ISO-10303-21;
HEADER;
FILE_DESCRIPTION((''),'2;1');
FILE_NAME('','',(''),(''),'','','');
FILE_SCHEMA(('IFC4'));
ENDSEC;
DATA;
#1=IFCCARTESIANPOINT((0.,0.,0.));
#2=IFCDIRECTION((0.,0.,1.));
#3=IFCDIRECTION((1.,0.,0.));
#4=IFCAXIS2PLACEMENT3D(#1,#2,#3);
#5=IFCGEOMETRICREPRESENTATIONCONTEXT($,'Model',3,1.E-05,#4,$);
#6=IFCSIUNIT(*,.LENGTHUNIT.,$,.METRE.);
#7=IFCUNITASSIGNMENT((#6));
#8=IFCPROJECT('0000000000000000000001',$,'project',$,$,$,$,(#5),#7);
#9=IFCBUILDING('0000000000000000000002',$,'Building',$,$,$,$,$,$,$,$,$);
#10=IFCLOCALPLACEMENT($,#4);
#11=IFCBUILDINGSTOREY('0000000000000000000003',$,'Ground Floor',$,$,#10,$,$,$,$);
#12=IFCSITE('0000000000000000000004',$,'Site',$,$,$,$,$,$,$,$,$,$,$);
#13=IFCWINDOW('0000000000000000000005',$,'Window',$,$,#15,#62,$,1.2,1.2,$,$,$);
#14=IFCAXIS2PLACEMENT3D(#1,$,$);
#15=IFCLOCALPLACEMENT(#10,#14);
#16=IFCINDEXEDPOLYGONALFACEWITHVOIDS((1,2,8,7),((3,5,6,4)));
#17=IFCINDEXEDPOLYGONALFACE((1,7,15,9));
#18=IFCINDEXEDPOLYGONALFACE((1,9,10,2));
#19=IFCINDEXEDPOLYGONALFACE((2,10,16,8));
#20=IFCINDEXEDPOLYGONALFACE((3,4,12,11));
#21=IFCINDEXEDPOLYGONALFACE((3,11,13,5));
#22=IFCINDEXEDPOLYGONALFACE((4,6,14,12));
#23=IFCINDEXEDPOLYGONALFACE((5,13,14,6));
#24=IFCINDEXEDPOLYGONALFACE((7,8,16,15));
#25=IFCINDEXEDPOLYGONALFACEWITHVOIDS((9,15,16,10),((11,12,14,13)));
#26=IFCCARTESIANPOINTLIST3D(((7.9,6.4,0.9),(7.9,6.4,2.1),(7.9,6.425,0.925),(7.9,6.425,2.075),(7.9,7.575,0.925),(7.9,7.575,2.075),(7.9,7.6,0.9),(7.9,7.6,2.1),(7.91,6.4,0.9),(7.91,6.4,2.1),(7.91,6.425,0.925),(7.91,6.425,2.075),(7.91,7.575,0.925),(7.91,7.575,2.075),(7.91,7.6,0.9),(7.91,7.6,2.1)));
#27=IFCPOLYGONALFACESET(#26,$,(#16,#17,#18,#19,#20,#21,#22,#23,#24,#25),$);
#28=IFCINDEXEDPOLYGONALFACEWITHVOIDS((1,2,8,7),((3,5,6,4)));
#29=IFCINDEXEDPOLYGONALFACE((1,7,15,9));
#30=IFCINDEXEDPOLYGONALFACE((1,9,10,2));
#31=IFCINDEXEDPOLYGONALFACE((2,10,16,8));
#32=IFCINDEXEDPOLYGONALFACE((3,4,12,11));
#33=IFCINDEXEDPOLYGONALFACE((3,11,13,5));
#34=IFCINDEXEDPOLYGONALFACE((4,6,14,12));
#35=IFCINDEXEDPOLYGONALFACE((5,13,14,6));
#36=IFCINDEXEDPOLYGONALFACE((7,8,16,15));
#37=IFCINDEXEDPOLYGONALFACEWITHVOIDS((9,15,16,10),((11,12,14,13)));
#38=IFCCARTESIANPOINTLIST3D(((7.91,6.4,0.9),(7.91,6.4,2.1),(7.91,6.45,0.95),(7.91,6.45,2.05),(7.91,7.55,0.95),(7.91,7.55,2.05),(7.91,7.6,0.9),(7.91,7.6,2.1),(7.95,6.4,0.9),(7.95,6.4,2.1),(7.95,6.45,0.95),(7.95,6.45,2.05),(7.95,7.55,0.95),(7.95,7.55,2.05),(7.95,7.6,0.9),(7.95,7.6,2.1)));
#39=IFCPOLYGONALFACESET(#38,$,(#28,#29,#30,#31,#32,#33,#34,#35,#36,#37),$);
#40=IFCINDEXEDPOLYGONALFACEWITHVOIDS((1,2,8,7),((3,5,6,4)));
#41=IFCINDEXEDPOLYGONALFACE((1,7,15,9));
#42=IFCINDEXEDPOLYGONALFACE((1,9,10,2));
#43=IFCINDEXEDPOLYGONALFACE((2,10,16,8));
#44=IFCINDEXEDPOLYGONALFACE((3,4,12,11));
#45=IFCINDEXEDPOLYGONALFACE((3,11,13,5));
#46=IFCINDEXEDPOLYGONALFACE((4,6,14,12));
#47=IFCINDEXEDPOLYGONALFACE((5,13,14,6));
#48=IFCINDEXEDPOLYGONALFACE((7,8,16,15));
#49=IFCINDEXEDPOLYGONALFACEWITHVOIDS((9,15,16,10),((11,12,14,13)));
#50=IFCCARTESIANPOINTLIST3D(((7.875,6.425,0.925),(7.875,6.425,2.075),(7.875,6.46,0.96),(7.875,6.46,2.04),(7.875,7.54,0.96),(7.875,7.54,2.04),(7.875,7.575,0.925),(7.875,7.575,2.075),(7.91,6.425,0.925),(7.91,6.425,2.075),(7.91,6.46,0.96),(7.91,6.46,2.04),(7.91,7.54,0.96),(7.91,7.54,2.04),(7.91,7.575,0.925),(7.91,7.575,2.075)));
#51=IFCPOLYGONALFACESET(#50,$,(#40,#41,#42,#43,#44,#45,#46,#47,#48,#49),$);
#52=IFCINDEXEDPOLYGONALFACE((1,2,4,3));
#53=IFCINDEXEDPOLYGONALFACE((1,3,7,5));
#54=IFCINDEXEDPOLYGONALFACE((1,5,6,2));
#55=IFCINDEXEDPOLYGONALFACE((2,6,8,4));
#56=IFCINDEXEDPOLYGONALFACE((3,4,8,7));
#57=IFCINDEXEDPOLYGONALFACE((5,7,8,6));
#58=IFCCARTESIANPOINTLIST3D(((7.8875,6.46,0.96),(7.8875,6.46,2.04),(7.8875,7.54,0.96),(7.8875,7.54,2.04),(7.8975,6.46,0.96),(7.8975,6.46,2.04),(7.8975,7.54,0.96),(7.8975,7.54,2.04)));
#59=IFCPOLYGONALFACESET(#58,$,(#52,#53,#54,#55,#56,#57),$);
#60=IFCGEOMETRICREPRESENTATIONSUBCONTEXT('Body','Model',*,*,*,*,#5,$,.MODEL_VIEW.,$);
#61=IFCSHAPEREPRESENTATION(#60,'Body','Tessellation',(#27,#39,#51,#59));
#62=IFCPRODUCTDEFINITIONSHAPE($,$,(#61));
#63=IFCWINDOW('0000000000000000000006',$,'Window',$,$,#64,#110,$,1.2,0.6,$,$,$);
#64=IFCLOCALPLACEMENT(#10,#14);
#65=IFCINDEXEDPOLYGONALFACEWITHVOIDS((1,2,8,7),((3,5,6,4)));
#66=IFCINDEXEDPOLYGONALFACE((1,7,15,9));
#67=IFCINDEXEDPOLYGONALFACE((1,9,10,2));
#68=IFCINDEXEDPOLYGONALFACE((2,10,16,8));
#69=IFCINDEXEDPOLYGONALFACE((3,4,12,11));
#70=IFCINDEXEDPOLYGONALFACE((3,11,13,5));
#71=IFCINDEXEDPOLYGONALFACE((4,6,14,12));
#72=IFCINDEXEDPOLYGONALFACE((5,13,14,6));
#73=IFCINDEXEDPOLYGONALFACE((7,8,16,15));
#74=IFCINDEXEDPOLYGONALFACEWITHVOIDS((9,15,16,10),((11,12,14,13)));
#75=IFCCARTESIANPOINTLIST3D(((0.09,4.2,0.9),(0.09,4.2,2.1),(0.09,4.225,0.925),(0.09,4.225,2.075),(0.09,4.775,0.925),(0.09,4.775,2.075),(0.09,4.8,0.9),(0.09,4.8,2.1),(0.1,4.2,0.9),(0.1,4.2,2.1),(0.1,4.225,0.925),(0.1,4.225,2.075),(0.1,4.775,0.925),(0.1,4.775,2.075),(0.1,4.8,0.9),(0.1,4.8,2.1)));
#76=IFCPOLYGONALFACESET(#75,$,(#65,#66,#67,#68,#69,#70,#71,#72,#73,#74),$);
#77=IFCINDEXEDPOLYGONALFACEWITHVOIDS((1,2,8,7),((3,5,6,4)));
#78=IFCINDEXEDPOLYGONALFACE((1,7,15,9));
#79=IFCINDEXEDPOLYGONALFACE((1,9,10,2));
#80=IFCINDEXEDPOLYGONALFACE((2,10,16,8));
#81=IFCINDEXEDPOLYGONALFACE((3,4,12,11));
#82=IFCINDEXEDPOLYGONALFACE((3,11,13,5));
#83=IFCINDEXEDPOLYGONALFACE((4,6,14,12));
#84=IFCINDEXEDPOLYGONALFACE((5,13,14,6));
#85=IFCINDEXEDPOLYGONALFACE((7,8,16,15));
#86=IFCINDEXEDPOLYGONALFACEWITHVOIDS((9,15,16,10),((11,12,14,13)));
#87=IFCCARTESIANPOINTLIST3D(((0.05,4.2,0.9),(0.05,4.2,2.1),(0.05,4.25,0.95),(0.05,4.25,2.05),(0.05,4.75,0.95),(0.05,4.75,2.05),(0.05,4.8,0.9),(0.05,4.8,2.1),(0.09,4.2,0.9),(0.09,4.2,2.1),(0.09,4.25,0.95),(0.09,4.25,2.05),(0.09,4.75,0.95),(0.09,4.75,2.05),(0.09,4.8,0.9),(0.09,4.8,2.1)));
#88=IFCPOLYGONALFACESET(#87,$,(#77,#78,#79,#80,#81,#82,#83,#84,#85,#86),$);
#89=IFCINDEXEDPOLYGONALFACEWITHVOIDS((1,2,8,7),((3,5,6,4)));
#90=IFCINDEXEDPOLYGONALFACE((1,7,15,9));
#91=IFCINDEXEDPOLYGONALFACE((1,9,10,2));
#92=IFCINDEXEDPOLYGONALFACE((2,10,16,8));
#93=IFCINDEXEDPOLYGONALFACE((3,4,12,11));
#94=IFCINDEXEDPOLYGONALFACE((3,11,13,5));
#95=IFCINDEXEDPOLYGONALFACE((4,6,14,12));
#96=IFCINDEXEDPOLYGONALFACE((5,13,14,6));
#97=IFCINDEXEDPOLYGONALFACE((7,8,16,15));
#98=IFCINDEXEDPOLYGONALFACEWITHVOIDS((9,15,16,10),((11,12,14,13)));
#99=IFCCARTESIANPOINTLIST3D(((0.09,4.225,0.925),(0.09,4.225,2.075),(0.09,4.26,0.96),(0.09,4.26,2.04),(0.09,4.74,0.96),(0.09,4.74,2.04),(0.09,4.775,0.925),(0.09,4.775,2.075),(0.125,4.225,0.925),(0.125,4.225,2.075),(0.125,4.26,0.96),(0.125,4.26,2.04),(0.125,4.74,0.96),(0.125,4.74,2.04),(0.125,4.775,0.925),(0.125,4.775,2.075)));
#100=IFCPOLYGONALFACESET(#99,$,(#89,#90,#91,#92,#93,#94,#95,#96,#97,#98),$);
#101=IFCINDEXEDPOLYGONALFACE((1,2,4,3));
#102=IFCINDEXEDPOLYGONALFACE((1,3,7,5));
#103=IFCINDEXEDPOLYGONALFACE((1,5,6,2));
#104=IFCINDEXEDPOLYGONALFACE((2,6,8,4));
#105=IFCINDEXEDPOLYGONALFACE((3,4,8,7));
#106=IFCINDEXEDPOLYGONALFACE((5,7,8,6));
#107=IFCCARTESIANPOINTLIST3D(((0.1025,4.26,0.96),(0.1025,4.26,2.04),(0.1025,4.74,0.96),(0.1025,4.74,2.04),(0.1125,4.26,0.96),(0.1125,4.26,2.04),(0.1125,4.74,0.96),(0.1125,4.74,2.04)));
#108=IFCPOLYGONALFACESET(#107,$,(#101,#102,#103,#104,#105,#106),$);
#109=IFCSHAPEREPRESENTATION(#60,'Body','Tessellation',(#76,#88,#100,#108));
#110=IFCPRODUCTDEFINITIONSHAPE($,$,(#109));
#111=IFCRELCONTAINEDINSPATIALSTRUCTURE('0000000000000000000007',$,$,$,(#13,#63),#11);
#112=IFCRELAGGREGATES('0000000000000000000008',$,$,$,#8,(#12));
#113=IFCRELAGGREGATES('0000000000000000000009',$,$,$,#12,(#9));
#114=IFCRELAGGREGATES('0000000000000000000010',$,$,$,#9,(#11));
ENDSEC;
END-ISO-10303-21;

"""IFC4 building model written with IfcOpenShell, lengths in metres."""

from ifc_helpers import new_model, si_unit, frame, origin_with_axes, place, context, subcontext, project, spatial, line, indexed_curve, outline, extrude, element, save


model = new_model("IFC4")

# Units and contexts
model_context = context("Model", 3, precision=1e-05, world=origin_with_axes())
body_context = subcontext(model_context, "Body", "Model", "MODEL_VIEW")
ifc_project = project(units=[si_unit("LENGTHUNIT", "METRE")], contexts=[model_context])

# Site, building, storey
site = spatial("IfcSite", under=ifc_project, Name="Site")
building = spatial("IfcBuilding", under=site, Name="Building")
storey_placement = place(None, origin_with_axes())
storey = spatial("IfcBuildingStorey", under=building, at=storey_placement, Name="Ground Floor")

# Windows
window_1_placement = place(storey_placement, frame((8.0, 6.4, 0.9), z_axis=(0.0, 0.0, 1.0), x_axis=(0.0, 1.0, 0.0)))
element("IfcWindow", 1, at=window_1_placement, inside=storey, Name="Window", OverallHeight=1.2, OverallWidth=1.2, context=body_context, shape_type="SweptSolid", body=[
    extrude(outline(indexed_curve([(0.0, 0.0), (1.2, 0.0), (1.2, 1.2), (0.0, 1.2)], segments=[line(1, 2, 3, 4, 1)]), holes=[indexed_curve([(0.025, 0.025), (1.175, 0.025), (1.175, 1.175), (0.025, 1.175)], segments=[line(1, 2, 3, 4, 1)])]), frame((0.0, 0.09, 0.0), z_axis=(0.0, -1.0, 0.0), x_axis=(1.0, 0.0, 0.0)), (0.0, 0.0, -1.0), 0.01),
    extrude(outline(indexed_curve([(0.0, 0.0), (1.2, 0.0), (1.2, 1.2), (0.0, 1.2)], segments=[line(1, 2, 3, 4, 1)]), holes=[indexed_curve([(0.05, 0.05), (1.15, 0.05), (1.15, 1.15), (0.05, 1.15)], segments=[line(1, 2, 3, 4, 1)])]), frame((0.0, 0.05, 0.0), z_axis=(0.0, -1.0, 0.0), x_axis=(1.0, 0.0, 0.0)), (0.0, 0.0, -1.0), 0.04),
    extrude(outline(indexed_curve([(0.0, 0.0), (1.15, 0.0), (1.15, 1.15), (0.0, 1.15)], segments=[line(1, 2, 3, 4, 1)]), holes=[indexed_curve([(0.035, 0.035), (1.115, 0.035), (1.115, 1.115), (0.035, 1.115)], segments=[line(1, 2, 3, 4, 1)])]), frame((0.025, 0.09, 0.025), z_axis=(0.0, -1.0, 0.0), x_axis=(1.0, 0.0, 0.0)), (0.0, 0.0, -1.0), 0.035),
    extrude(outline(indexed_curve([(0.035, 0.035), (1.115, 0.035), (1.115, 1.115), (0.035, 1.115)], segments=[line(1, 2, 3, 4, 1)])), frame((0.025, 0.1025, 0.025), z_axis=(0.0, -1.0, 0.0), x_axis=(1.0, 0.0, 0.0)), (0.0, 0.0, -1.0), 0.01),
])
window_2_placement = place(storey_placement, frame((0.0, 4.8, 0.9), z_axis=(0.0, 0.0, 1.0), x_axis=(0.0, -1.0, 0.0)))
element("IfcWindow", 2, at=window_2_placement, inside=storey, Name="Window", OverallHeight=1.2, OverallWidth=0.6, context=body_context, shape_type="SweptSolid", body=[
    extrude(outline(indexed_curve([(0.0, 0.0), (0.6, 0.0), (0.6, 1.2), (0.0, 1.2)], segments=[line(1, 2, 3, 4, 1)]), holes=[indexed_curve([(0.025, 0.025), (0.575, 0.025), (0.575, 1.175), (0.025, 1.175)], segments=[line(1, 2, 3, 4, 1)])]), frame((0.0, 0.09, 0.0), z_axis=(0.0, -1.0, 0.0), x_axis=(1.0, 0.0, 0.0)), (0.0, 0.0, -1.0), 0.01),
    extrude(outline(indexed_curve([(0.0, 0.0), (0.6, 0.0), (0.6, 1.2), (0.0, 1.2)], segments=[line(1, 2, 3, 4, 1)]), holes=[indexed_curve([(0.05, 0.05), (0.55, 0.05), (0.55, 1.15), (0.05, 1.15)], segments=[line(1, 2, 3, 4, 1)])]), frame((0.0, 0.05, 0.0), z_axis=(0.0, -1.0, 0.0), x_axis=(1.0, 0.0, 0.0)), (0.0, 0.0, -1.0), 0.04),
    extrude(outline(indexed_curve([(0.0, 0.0), (0.55, 0.0), (0.55, 1.15), (0.0, 1.15)], segments=[line(1, 2, 3, 4, 1)]), holes=[indexed_curve([(0.035, 0.035), (0.515, 0.035), (0.515, 1.115), (0.035, 1.115)], segments=[line(1, 2, 3, 4, 1)])]), frame((0.025, 0.09, 0.025), z_axis=(0.0, -1.0, 0.0), x_axis=(1.0, 0.0, 0.0)), (0.0, 0.0, -1.0), 0.035),
    extrude(outline(indexed_curve([(0.035, 0.035), (0.515, 0.035), (0.515, 1.115), (0.035, 1.115)], segments=[line(1, 2, 3, 4, 1)])), frame((0.025, 0.1025, 0.025), z_axis=(0.0, -1.0, 0.0), x_axis=(1.0, 0.0, 0.0)), (0.0, 0.0, -1.0), 0.01),
])

save(model, "model.ifc")
